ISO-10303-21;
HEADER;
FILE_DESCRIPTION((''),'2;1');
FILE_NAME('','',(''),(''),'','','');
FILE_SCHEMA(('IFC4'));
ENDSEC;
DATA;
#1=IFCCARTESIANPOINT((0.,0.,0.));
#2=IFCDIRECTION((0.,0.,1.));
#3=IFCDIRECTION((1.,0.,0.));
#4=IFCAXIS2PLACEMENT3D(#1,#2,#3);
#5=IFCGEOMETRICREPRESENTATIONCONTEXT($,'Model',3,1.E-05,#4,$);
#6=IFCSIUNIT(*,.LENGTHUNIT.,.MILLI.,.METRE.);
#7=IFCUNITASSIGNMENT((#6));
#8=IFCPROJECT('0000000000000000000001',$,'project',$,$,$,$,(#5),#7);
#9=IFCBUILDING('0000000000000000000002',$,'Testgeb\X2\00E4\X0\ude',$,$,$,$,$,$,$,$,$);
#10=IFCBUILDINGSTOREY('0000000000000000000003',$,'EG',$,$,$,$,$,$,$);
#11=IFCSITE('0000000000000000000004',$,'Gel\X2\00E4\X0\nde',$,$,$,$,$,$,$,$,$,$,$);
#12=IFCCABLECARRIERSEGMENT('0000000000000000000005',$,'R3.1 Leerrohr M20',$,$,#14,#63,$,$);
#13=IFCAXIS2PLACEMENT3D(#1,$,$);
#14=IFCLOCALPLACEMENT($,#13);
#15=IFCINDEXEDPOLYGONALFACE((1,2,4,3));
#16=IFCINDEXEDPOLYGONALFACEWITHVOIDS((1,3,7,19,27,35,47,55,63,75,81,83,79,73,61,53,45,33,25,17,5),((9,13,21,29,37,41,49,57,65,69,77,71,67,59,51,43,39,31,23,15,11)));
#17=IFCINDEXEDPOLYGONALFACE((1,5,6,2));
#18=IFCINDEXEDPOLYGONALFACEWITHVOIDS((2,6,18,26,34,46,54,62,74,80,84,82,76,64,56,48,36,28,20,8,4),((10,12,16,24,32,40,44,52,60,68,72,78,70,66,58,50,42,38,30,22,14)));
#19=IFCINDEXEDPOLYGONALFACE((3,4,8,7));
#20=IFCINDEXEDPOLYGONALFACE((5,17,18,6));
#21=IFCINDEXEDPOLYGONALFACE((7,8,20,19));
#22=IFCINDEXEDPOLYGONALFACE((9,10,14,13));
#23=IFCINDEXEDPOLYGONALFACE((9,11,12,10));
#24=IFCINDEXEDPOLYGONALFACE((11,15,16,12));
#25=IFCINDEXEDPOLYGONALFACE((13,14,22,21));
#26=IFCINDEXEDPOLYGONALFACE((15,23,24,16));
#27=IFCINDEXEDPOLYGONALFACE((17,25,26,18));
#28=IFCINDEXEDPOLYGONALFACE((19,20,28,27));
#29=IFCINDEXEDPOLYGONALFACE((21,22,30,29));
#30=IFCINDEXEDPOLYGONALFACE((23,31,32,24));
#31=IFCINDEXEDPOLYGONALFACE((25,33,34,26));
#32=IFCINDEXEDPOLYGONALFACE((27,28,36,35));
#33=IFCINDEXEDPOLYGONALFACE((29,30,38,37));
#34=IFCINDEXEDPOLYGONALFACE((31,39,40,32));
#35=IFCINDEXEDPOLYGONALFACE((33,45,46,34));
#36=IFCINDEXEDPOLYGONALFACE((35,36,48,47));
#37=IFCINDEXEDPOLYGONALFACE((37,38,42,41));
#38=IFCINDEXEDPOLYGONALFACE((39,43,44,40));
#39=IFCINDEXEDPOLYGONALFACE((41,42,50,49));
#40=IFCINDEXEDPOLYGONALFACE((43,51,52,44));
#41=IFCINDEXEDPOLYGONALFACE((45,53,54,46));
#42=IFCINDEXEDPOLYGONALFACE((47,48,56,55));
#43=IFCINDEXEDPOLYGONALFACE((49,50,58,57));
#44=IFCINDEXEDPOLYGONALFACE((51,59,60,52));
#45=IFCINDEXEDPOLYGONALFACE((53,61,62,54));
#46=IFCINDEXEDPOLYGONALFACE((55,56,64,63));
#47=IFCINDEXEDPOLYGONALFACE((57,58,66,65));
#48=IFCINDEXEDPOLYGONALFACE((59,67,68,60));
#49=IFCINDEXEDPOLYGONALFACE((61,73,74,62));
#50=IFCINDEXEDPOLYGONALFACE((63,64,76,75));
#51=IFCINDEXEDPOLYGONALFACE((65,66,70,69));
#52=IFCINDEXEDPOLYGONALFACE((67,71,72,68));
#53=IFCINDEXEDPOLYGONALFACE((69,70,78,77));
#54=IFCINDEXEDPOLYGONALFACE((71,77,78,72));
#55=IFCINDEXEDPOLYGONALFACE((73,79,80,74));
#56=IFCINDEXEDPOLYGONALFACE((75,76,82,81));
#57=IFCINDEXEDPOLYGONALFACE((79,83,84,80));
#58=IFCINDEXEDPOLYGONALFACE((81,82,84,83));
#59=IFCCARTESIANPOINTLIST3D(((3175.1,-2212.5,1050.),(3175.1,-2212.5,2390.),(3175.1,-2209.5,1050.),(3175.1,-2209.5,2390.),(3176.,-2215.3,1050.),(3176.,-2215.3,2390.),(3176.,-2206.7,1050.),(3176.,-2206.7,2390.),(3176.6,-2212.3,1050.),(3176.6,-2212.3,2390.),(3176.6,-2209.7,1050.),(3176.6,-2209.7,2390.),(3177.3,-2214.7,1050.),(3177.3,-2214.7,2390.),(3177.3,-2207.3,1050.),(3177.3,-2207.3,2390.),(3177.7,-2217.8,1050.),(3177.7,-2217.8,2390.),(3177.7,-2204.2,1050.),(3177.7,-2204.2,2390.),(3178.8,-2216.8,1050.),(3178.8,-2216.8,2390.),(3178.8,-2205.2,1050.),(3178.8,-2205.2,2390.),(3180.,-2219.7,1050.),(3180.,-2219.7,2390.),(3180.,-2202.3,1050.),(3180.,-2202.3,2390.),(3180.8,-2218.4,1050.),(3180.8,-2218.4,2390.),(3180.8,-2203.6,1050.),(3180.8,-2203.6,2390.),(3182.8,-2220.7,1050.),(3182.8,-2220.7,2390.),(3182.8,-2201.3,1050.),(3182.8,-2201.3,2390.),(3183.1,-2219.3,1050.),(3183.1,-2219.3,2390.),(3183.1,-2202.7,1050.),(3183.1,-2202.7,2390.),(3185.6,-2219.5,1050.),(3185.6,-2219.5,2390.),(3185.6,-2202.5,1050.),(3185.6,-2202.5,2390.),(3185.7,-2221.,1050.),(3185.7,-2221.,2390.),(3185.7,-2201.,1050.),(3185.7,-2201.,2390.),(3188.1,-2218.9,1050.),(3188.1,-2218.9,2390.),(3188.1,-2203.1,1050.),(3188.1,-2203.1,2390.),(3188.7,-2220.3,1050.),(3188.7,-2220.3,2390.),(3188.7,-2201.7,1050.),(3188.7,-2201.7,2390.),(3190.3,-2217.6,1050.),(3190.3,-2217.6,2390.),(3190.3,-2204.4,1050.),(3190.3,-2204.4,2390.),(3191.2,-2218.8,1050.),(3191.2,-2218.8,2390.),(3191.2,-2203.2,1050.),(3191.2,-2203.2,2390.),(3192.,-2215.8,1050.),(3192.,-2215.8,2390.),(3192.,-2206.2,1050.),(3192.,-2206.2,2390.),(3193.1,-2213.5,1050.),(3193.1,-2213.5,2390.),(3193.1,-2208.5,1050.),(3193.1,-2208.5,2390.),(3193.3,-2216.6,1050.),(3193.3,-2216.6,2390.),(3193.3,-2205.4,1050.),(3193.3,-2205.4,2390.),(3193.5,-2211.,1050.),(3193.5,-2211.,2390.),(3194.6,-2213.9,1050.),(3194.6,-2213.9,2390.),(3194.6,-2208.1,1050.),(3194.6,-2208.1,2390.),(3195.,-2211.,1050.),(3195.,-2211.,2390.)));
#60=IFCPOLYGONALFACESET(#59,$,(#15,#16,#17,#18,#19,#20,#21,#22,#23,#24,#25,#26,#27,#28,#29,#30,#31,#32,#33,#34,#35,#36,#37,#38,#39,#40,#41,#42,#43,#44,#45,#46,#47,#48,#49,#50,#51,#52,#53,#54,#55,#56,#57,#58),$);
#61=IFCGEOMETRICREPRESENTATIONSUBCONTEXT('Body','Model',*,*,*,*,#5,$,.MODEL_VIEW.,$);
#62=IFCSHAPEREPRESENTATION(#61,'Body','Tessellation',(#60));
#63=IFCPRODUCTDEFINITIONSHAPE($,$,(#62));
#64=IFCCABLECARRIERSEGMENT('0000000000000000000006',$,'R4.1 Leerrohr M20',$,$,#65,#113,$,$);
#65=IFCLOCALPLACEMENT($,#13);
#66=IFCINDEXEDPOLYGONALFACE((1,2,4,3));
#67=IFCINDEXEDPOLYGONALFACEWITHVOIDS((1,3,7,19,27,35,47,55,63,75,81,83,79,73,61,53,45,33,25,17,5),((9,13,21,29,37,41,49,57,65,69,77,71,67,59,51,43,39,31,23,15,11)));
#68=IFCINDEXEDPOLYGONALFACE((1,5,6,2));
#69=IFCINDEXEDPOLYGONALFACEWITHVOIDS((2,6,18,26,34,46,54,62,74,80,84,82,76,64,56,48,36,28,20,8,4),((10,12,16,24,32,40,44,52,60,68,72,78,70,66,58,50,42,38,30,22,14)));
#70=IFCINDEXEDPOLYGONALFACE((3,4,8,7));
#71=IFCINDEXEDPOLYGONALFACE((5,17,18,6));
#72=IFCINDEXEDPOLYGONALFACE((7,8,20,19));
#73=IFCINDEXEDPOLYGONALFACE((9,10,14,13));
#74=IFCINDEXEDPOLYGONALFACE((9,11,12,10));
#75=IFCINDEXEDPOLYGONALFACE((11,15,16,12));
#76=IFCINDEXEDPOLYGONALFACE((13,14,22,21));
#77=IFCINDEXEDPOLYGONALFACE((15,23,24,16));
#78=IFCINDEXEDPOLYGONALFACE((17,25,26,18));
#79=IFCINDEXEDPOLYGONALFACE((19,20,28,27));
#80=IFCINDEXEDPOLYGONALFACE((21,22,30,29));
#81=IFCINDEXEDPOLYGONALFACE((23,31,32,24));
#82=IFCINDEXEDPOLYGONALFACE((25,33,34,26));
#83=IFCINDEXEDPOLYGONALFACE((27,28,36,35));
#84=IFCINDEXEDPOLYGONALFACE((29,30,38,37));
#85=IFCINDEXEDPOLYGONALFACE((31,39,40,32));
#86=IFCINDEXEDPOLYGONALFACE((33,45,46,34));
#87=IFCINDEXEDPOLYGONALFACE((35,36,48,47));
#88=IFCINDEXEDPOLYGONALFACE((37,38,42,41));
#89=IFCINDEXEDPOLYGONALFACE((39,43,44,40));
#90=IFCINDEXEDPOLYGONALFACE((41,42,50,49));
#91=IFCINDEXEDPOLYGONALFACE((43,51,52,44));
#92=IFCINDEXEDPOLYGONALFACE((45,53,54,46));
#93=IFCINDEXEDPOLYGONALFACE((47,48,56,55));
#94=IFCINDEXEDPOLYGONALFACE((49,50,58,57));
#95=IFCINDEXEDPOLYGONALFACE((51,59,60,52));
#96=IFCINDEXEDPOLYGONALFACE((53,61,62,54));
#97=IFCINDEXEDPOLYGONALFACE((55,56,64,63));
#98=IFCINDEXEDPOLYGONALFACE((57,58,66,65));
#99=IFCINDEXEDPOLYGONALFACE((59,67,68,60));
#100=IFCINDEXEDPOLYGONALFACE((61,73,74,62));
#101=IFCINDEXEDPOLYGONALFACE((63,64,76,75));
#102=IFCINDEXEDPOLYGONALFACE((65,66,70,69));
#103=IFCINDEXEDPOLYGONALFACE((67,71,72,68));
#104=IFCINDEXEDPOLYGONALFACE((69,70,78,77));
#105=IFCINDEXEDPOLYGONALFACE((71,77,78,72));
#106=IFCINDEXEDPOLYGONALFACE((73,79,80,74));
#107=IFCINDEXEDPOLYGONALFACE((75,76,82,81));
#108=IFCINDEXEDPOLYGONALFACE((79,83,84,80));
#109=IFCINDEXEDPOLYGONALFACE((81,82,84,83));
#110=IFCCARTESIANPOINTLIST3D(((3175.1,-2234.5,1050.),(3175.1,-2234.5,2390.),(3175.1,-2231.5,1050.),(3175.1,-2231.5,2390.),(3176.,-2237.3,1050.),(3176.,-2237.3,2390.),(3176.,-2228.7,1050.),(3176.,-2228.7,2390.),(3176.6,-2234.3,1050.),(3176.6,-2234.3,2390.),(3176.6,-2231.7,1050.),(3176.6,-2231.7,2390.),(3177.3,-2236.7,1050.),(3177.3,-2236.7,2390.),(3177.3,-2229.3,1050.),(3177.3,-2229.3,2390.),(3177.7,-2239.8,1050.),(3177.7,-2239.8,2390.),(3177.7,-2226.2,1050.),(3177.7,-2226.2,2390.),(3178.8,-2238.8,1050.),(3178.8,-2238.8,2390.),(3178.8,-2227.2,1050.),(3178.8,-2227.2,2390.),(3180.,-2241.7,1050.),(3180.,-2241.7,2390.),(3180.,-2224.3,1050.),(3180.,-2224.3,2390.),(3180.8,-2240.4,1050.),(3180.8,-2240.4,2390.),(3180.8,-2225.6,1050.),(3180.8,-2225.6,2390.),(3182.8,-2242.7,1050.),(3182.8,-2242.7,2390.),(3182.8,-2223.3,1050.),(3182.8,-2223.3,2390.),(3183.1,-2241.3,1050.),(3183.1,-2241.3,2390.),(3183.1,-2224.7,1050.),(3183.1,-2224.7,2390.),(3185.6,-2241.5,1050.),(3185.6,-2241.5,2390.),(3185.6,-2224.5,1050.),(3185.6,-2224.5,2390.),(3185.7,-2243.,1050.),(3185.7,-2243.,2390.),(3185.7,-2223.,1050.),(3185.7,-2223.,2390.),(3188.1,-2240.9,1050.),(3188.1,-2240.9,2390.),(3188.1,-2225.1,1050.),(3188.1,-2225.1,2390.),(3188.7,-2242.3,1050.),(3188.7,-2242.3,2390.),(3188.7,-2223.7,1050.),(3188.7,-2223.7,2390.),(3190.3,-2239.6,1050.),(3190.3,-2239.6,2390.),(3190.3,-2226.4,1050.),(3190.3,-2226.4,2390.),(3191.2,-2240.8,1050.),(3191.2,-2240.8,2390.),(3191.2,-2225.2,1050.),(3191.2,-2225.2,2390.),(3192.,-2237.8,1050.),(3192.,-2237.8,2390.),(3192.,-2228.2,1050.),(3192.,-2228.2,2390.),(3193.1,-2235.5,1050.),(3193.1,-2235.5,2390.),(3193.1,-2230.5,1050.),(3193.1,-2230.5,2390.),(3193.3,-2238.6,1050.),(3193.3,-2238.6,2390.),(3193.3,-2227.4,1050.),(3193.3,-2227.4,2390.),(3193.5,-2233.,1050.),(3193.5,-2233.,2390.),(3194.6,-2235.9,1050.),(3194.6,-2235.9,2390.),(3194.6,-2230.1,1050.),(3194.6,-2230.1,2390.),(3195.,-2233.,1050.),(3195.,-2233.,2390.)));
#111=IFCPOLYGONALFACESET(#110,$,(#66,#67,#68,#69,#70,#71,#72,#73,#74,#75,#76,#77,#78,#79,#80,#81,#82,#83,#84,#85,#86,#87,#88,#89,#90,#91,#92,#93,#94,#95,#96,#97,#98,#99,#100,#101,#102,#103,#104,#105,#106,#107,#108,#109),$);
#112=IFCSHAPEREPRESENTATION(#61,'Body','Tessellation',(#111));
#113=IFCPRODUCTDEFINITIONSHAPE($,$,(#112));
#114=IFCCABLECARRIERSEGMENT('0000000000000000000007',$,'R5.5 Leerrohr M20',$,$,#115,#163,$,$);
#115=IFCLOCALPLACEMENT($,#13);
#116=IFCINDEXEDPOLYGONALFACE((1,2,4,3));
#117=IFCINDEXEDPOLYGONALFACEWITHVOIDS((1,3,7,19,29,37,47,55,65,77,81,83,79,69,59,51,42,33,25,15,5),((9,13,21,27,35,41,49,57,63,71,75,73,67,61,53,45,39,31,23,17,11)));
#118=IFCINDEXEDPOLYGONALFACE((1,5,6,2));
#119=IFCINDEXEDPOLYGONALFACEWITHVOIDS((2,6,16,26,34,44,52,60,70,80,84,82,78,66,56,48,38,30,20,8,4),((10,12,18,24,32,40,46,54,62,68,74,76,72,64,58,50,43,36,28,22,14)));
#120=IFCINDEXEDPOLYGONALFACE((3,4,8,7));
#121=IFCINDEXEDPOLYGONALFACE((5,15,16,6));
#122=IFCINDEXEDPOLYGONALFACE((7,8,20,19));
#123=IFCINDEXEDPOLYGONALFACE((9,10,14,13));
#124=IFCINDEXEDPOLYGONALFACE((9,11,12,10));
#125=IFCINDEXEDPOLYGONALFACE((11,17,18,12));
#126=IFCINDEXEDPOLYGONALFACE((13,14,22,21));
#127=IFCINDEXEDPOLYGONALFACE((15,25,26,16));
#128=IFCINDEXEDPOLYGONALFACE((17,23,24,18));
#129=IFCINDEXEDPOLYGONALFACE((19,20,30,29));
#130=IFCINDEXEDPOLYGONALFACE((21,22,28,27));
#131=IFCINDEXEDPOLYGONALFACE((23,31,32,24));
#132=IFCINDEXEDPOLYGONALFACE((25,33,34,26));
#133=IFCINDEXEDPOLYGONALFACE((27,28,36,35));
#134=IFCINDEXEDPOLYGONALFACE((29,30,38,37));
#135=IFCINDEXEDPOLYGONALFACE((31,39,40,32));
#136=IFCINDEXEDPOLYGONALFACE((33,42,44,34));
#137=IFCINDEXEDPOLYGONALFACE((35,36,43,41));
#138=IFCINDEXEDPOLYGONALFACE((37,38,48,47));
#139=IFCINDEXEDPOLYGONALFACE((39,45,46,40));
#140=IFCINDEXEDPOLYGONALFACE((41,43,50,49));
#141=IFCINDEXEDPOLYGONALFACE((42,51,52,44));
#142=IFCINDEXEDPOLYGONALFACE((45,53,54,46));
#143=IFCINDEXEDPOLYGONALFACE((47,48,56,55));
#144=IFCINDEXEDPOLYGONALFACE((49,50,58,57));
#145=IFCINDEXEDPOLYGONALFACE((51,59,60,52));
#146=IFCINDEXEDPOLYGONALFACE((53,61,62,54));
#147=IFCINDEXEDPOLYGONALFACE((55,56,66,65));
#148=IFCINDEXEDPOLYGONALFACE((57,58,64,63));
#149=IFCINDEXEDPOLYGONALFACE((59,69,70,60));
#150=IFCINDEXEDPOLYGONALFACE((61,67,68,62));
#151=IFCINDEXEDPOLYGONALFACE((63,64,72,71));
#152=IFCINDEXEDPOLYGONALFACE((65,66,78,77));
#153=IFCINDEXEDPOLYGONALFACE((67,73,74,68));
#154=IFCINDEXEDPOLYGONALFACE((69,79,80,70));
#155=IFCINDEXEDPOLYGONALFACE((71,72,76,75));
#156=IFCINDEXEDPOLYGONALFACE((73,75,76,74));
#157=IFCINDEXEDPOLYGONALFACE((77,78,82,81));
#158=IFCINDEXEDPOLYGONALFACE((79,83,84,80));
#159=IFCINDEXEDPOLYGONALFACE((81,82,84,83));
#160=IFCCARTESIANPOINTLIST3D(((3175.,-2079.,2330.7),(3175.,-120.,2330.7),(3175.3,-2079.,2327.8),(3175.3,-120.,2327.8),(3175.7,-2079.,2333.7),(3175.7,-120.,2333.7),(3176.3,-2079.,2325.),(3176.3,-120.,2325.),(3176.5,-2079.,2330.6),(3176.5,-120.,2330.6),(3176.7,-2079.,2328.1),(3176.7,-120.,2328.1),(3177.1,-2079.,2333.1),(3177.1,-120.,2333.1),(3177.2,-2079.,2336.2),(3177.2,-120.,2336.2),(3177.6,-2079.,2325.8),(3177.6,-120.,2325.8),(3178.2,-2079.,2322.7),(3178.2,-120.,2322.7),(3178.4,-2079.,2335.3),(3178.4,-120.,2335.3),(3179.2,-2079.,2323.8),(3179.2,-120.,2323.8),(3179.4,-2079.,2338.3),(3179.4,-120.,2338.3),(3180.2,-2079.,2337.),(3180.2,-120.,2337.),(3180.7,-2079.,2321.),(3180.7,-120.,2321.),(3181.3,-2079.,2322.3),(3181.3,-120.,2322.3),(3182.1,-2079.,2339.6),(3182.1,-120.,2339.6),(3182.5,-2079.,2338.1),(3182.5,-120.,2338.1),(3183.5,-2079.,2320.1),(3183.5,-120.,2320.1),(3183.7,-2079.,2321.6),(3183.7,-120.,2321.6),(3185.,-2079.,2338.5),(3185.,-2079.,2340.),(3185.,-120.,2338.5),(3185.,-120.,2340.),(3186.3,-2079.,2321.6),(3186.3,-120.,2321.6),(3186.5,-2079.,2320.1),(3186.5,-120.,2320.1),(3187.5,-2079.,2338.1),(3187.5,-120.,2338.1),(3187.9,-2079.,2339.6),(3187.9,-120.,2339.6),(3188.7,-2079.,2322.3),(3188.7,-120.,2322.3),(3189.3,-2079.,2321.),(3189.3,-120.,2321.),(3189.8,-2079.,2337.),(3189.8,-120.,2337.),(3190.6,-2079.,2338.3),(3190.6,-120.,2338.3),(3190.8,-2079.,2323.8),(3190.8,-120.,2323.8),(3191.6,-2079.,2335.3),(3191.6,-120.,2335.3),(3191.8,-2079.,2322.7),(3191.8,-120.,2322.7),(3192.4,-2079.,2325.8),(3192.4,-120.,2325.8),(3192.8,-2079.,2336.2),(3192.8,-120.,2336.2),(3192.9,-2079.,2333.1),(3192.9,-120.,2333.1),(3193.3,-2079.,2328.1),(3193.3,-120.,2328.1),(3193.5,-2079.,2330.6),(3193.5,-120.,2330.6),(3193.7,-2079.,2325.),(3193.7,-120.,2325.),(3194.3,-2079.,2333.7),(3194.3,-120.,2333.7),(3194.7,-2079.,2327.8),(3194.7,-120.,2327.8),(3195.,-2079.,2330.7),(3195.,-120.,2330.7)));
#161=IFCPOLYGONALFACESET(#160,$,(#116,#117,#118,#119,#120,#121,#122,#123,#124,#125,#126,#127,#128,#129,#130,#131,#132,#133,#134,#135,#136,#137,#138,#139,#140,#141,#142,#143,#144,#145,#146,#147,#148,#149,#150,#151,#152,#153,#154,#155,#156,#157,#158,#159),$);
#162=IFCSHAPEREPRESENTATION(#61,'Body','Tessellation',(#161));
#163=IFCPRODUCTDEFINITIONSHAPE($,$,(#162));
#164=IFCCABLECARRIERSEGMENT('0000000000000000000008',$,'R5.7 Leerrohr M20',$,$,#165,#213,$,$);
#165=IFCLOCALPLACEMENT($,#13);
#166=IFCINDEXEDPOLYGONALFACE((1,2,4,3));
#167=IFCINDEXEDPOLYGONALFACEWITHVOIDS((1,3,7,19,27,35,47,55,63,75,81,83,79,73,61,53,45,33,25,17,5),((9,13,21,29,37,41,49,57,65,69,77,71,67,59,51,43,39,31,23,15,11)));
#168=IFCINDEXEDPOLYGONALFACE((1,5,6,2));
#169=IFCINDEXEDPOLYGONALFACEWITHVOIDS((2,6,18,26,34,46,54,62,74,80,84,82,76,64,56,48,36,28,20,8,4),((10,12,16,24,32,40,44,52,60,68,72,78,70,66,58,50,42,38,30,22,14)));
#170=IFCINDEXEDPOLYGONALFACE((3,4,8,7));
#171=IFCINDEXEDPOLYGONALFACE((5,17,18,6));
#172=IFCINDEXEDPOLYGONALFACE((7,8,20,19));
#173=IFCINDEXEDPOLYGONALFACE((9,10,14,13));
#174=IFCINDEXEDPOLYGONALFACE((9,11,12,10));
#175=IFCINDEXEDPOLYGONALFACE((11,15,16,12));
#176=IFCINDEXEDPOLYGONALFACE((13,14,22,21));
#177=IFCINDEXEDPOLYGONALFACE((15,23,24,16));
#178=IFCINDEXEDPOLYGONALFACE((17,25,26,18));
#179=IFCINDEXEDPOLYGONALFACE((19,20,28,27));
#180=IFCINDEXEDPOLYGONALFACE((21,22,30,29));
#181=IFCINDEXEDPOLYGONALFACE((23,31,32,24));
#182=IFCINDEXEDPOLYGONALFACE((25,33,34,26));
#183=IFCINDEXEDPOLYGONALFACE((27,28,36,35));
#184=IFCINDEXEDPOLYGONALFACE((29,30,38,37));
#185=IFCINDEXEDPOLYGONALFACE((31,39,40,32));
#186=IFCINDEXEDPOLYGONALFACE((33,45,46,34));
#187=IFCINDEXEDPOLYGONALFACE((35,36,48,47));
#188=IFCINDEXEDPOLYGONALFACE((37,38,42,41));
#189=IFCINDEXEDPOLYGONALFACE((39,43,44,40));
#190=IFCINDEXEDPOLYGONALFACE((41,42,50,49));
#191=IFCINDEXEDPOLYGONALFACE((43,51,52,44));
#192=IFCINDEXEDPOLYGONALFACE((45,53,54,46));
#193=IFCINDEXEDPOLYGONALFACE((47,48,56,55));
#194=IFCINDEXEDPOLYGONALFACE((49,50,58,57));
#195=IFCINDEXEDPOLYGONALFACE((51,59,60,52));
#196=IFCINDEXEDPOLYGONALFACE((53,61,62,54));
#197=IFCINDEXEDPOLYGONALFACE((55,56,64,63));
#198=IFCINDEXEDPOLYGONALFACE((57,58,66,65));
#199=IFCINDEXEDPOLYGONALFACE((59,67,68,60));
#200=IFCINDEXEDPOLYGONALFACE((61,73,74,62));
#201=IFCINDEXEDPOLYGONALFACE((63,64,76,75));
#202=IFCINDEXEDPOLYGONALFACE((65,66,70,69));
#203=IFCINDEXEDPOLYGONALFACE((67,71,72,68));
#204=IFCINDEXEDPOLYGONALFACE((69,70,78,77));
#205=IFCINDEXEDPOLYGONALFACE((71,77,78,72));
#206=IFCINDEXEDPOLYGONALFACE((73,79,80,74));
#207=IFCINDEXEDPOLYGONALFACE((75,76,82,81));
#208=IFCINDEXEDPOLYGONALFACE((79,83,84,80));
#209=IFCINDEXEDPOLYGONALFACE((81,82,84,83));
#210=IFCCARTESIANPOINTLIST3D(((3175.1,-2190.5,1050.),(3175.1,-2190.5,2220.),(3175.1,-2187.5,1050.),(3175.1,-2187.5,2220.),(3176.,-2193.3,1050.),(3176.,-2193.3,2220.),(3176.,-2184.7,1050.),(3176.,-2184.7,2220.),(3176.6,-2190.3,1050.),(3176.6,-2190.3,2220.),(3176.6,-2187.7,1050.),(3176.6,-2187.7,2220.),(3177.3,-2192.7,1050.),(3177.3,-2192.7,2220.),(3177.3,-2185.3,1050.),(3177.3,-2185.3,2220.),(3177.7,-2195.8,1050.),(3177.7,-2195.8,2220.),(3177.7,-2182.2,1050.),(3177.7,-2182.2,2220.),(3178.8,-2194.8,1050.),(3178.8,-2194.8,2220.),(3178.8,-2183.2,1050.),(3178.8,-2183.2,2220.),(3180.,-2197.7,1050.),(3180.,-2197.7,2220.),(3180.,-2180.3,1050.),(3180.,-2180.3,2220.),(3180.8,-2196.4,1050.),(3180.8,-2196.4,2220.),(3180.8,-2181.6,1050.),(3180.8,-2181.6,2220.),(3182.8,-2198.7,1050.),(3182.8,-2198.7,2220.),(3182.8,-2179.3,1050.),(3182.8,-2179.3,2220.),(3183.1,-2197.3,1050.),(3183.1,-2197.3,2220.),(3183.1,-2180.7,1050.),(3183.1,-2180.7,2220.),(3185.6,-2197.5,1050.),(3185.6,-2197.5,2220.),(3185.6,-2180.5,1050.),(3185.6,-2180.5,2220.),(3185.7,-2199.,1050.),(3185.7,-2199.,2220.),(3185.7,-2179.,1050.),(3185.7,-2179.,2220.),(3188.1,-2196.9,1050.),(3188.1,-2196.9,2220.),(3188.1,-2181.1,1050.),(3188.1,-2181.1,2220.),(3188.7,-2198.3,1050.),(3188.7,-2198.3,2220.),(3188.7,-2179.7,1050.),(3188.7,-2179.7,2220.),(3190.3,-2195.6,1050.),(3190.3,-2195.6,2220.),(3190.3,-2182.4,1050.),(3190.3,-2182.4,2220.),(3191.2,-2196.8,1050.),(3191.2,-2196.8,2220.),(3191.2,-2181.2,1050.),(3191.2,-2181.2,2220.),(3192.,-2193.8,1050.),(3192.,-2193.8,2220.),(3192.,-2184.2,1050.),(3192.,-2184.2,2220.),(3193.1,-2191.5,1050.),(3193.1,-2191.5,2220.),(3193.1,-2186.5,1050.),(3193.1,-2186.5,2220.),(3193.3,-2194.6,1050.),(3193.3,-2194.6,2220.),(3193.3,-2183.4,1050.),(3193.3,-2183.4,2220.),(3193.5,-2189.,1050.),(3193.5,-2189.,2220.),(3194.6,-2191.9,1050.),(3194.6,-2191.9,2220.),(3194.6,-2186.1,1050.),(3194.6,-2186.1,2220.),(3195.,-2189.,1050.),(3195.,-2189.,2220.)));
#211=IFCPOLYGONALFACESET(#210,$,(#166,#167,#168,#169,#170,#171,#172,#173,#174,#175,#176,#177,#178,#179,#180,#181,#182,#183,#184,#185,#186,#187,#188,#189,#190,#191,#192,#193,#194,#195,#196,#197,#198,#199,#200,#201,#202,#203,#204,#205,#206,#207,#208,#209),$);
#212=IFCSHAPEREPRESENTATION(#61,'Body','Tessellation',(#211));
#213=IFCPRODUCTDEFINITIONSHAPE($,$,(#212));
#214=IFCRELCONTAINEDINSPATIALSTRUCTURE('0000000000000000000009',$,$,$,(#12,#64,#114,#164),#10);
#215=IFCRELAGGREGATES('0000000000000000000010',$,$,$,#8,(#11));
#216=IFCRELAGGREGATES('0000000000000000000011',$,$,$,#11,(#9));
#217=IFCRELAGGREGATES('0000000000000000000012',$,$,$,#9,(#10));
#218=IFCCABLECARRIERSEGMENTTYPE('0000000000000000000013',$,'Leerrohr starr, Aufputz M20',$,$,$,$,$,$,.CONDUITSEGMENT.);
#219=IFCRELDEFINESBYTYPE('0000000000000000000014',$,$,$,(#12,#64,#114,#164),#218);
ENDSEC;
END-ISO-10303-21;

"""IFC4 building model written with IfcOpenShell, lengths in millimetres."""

from ifc_helpers import new_model, si_unit, frame, origin_with_axes, place, context, subcontext, project, spatial, hollow_circle, extrude, type_object, element, save


model = new_model("IFC4")

# Units and contexts
model_context = context("Model", 3, precision=1e-05, world=origin_with_axes())
body_context = subcontext(model_context, "Body", "Model", "MODEL_VIEW")
ifc_project = project(units=[si_unit("LENGTHUNIT", "METRE", prefix="MILLI")], contexts=[model_context])

# Site, building, storey
site = spatial("IfcSite", under=ifc_project, Name="Gelände")
building = spatial("IfcBuilding", under=site, Name="Testgebäude")
storey = spatial("IfcBuildingStorey", under=building, Name="EG")

# Cable carrier segments
cable_carrier_segment_type_1 = type_object("IfcCableCarrierSegmentType", Name="Leerrohr starr, Aufputz M20", PredefinedType="CONDUITSEGMENT")
for number, where, z_axis, x_axis, name in (
    (1, (3185.0, -2211.0, 1050.0), (0.0, 0.0, 1.0), (1.0, 0.0, 0.0), "R3.1 Leerrohr M20"),
    (2, (3185.0, -2233.0, 1050.0), (0.0, 0.0, 1.0), (1.0, 0.0, 0.0), "R4.1 Leerrohr M20"),
):
    element("IfcCableCarrierSegment", number, at=place(None, frame(where, z_axis=z_axis, x_axis=x_axis)), inside=storey, type_object=cable_carrier_segment_type_1, Name=name, context=body_context, shape_type="SweptSolid", body=[
        extrude(hollow_circle(Radius=10.0, WallThickness=1.5), None, (0.0, 0.0, 1.0), 1340.0),
    ])
cable_carrier_segment_1_placement = place(None, frame((3185.0, -120.0, 2330.0), z_axis=(0.0, -1.0, 0.0), x_axis=(0.0, 0.0, 1.0)))
element("IfcCableCarrierSegment", 3, at=cable_carrier_segment_1_placement, inside=storey, type_object=cable_carrier_segment_type_1, Name="R5.5 Leerrohr M20", context=body_context, shape_type="SweptSolid", body=[
    extrude(hollow_circle(Radius=10.0, WallThickness=1.5), None, (0.0, 0.0, 1.0), 1959.0),
])
cable_carrier_segment_2_placement = place(None, frame((3185.0, -2189.0, 2220.0), z_axis=(0.0, 0.0, -1.0), x_axis=(1.0, 0.0, 0.0)))
element("IfcCableCarrierSegment", 4, at=cable_carrier_segment_2_placement, inside=storey, type_object=cable_carrier_segment_type_1, Name="R5.7 Leerrohr M20", context=body_context, shape_type="SweptSolid", body=[
    extrude(hollow_circle(Radius=10.0, WallThickness=1.5), None, (0.0, 0.0, 1.0), 1170.0),
])

save(model, "model.ifc")
